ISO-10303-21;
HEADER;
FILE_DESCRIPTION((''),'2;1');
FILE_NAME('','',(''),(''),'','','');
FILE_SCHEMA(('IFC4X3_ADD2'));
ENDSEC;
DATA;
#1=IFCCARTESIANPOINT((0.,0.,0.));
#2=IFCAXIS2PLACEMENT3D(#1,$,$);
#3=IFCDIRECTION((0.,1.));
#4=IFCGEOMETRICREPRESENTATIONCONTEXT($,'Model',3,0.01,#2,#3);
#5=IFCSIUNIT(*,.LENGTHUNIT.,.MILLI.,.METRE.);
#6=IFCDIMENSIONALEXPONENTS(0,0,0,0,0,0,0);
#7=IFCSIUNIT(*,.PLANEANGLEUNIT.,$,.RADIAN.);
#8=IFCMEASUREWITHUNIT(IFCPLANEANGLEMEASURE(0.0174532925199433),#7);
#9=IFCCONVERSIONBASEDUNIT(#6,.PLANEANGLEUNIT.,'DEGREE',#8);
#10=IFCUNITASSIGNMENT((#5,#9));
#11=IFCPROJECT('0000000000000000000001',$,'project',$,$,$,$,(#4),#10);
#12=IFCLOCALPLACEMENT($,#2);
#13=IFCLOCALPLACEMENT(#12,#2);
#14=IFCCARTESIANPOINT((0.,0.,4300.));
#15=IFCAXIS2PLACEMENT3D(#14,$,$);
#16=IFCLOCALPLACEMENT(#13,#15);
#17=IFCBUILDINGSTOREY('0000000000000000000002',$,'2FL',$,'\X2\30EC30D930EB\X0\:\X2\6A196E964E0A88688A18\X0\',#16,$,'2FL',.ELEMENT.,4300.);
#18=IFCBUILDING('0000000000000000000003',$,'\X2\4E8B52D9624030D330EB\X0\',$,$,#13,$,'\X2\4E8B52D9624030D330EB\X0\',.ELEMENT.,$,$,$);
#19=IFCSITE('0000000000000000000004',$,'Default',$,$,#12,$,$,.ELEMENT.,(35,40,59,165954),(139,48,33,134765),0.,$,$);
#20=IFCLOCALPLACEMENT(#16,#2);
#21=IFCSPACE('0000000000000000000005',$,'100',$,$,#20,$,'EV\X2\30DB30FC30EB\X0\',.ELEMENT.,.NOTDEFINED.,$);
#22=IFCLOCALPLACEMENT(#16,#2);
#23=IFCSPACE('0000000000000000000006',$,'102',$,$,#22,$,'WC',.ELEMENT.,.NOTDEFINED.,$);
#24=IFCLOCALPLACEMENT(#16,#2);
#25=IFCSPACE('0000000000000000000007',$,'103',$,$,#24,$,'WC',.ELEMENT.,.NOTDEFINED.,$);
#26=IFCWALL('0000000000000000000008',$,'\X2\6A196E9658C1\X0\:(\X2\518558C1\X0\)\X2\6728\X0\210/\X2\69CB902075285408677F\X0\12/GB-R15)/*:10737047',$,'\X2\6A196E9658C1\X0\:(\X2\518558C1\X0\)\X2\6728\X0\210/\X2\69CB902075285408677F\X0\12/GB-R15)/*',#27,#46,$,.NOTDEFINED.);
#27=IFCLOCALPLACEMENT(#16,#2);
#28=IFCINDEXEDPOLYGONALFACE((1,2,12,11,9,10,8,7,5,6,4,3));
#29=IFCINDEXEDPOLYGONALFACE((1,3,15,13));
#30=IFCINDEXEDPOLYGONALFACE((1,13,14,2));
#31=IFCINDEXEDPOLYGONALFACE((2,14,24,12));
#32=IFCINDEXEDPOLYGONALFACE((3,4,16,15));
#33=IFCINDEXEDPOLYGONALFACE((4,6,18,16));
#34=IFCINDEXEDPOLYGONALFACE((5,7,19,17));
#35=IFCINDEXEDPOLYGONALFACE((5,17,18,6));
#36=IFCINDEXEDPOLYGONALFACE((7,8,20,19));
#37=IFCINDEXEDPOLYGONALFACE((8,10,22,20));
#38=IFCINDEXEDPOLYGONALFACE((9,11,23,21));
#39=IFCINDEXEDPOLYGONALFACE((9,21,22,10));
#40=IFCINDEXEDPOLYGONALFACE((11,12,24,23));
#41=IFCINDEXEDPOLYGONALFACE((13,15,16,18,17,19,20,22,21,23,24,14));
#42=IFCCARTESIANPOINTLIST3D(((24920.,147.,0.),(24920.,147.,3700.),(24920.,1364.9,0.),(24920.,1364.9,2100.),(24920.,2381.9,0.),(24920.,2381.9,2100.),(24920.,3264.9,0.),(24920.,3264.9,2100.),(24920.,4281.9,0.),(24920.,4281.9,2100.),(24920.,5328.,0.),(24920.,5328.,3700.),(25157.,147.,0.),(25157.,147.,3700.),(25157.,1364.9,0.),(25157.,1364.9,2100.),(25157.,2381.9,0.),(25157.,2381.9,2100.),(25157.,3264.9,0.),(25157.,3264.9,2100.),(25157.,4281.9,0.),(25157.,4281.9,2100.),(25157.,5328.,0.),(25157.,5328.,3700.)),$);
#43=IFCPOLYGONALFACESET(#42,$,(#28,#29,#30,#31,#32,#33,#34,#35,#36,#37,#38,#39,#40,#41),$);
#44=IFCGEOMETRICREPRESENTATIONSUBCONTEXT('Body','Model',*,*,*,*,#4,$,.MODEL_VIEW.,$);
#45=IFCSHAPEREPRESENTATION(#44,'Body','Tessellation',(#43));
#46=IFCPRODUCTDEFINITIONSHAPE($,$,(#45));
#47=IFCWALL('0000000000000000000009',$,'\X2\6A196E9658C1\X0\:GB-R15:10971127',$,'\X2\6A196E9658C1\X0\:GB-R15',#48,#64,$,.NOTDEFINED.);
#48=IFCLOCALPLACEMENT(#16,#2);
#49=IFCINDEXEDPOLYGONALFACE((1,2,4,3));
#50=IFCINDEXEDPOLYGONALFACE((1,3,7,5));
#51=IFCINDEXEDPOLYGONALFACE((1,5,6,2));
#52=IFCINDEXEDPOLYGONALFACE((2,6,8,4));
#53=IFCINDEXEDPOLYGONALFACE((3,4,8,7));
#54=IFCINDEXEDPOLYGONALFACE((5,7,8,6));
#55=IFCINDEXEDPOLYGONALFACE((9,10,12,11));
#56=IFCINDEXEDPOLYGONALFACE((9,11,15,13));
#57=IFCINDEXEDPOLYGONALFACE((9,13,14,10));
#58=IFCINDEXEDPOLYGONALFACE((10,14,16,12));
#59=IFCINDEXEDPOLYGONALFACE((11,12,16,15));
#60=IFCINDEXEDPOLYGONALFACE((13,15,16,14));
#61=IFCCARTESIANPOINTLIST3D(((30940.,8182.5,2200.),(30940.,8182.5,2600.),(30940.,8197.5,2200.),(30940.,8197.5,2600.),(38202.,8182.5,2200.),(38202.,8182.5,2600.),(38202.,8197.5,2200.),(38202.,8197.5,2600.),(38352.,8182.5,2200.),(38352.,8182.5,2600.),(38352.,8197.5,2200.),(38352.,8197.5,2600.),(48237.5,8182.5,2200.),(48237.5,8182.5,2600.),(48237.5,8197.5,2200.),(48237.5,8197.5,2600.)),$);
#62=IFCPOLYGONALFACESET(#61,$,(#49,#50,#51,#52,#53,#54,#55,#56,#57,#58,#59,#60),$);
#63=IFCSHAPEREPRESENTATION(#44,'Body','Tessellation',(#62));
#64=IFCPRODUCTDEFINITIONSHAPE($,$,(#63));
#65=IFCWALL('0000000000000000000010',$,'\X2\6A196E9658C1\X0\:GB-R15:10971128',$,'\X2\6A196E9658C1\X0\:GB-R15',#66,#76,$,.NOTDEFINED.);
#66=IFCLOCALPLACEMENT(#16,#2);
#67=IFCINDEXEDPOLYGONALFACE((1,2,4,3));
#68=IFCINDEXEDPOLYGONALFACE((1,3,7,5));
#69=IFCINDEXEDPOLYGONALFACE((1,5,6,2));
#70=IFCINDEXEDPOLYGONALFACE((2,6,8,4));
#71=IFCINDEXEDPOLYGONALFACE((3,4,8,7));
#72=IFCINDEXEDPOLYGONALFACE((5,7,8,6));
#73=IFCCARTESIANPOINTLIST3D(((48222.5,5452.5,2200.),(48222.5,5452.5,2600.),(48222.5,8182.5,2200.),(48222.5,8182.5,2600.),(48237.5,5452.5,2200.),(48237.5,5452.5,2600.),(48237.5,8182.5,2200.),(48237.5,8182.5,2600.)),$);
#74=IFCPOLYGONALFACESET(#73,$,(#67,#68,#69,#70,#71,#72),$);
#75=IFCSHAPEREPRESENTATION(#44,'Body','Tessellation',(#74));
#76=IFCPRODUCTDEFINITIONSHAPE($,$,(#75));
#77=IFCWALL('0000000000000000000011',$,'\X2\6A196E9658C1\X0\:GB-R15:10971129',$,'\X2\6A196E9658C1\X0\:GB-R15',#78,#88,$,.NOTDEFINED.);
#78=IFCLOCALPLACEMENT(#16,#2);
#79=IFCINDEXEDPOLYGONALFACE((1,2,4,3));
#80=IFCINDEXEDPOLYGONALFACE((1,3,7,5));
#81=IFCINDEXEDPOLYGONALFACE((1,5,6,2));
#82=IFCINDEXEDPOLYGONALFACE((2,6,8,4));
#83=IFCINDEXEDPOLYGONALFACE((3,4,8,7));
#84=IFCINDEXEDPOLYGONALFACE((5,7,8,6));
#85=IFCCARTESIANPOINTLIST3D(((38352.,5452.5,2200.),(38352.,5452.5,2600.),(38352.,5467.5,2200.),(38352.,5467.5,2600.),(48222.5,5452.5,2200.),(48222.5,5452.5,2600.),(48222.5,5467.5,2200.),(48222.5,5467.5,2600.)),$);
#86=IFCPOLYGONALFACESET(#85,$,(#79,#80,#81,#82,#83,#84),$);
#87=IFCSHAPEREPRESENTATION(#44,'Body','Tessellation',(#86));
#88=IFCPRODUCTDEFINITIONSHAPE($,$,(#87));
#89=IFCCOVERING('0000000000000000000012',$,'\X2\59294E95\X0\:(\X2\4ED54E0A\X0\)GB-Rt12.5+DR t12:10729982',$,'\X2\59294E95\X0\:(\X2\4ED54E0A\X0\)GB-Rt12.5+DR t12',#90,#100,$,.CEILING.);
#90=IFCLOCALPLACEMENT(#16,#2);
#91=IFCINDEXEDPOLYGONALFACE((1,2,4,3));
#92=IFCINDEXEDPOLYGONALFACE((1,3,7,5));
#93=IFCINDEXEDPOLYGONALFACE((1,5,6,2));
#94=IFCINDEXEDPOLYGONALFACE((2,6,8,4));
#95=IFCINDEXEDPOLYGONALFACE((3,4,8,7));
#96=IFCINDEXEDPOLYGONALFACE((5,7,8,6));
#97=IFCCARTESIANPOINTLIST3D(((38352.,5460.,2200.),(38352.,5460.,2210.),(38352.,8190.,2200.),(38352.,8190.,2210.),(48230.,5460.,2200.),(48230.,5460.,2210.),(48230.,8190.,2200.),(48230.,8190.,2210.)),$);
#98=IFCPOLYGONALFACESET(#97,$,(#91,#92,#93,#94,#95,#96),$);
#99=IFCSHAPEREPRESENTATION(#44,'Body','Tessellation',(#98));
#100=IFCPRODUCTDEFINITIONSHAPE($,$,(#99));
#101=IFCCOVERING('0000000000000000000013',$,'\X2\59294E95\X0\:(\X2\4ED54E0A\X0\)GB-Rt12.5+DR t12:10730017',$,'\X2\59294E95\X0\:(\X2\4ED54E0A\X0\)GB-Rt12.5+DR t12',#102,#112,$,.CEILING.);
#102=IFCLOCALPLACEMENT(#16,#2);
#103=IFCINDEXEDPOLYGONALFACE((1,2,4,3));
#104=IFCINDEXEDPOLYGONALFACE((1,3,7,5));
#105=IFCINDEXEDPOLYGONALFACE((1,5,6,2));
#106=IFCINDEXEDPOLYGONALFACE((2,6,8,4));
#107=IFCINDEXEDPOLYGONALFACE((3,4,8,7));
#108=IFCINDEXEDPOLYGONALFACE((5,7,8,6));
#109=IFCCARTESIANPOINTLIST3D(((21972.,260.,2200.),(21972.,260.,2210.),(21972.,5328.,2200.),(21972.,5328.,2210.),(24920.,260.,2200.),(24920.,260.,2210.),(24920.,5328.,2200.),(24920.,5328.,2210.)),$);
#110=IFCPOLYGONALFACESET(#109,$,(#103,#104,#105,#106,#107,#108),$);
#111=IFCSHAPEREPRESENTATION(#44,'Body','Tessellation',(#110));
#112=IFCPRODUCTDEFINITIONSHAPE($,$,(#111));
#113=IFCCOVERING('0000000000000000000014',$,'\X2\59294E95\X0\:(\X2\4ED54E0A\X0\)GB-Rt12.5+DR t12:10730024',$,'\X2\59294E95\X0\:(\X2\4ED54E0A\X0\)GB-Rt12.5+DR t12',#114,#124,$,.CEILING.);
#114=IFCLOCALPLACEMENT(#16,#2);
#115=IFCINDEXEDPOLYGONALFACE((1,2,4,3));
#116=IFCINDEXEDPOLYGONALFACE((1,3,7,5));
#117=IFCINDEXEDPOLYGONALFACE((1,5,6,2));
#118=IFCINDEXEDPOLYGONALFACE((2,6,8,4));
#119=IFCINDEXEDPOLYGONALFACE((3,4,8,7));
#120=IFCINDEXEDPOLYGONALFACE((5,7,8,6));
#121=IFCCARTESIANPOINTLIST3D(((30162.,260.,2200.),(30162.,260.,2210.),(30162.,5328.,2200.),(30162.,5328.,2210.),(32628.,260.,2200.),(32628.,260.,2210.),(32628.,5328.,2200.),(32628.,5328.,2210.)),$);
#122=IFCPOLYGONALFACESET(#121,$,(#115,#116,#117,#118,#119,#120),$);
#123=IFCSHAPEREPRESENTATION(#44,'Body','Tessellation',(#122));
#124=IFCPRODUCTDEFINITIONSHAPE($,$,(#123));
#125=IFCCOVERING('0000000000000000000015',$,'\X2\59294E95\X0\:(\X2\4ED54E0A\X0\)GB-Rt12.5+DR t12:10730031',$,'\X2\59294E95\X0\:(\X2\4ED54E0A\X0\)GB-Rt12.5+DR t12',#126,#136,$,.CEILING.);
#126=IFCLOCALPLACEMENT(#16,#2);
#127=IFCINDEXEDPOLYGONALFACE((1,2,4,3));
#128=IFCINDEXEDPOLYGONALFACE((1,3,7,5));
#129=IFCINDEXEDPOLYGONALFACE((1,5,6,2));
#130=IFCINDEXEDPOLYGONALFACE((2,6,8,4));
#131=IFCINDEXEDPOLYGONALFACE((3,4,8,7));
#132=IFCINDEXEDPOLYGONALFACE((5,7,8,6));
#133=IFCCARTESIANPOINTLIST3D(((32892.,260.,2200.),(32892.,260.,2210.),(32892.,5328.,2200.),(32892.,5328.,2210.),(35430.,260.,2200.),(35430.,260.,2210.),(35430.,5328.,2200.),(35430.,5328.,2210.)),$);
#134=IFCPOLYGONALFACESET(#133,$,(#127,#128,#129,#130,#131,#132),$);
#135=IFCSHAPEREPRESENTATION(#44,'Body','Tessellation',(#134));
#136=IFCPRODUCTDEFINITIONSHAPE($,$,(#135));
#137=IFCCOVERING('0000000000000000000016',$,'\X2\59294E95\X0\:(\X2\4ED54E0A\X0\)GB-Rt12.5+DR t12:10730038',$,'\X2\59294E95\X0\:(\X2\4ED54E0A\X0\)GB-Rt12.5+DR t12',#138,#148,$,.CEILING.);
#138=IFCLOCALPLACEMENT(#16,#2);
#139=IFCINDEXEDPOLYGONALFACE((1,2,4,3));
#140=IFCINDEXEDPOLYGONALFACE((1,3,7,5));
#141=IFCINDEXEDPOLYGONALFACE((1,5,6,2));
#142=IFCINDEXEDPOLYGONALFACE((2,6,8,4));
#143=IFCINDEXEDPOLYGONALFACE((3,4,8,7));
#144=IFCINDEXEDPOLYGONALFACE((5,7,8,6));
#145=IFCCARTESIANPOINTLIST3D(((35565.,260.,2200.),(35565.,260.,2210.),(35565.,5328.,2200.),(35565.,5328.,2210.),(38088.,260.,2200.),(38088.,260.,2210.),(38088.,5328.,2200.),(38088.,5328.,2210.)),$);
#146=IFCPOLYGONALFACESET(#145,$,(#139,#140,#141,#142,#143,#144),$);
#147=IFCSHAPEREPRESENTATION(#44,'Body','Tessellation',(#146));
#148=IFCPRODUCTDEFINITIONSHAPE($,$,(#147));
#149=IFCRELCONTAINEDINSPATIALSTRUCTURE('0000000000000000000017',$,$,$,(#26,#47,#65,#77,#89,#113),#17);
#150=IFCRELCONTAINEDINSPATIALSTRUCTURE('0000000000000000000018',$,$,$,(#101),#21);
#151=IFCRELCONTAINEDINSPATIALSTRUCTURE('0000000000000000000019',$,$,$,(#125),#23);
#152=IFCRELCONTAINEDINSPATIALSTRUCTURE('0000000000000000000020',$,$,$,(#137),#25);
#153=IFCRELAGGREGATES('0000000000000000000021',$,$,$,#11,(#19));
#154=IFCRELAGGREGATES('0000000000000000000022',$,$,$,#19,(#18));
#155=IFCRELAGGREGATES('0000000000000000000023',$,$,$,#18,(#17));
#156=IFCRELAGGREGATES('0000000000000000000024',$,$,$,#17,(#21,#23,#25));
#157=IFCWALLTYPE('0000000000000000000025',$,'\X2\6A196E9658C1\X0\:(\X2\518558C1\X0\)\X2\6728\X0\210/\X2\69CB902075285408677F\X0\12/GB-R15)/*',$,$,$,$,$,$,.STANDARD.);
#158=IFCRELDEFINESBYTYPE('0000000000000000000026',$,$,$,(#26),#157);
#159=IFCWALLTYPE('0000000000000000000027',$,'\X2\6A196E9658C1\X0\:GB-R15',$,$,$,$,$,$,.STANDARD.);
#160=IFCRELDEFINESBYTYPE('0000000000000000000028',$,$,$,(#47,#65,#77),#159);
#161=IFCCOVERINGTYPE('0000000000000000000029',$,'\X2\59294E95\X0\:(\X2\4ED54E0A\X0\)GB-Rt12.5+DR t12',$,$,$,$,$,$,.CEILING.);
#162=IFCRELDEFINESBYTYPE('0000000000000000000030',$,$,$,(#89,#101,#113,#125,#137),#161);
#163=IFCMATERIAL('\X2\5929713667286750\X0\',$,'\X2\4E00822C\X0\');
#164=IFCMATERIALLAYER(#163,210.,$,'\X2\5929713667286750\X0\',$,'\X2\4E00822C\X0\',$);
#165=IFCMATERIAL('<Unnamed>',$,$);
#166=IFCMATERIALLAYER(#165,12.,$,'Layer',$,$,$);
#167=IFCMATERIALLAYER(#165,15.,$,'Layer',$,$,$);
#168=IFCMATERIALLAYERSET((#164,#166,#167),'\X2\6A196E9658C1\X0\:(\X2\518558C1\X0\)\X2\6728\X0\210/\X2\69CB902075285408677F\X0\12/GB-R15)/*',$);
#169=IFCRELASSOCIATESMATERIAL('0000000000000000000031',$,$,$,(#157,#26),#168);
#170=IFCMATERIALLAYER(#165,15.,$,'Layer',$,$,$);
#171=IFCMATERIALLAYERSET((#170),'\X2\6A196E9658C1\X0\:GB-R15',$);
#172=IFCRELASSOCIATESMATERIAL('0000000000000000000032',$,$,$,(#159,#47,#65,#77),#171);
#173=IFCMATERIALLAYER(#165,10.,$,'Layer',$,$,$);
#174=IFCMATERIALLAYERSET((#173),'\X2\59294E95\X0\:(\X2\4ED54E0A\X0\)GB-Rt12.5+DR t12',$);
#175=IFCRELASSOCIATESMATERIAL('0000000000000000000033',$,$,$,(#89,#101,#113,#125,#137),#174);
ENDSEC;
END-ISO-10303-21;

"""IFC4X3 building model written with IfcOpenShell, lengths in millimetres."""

from ifc_helpers import new_model, entity, si_unit, converted_unit, direction, frame, frame_2d, origin, origin_2d_with_axis, place, context, subcontext, project, spatial, rectangle, extrude, material, layer, layer_set, layer_usage, type_object, element, save


model = new_model("IFC4X3")

# Units and contexts
model_context = context("Model", 3, precision=0.01, world=origin(), true_north=direction((0.0, 1.0)))
body_context = subcontext(model_context, "Body", "Model", "MODEL_VIEW")
ifc_project = project(units=[si_unit("LENGTHUNIT", "METRE", prefix="MILLI"), converted_unit("PLANEANGLEUNIT", "DEGREE", entity("IfcPlaneAngleMeasure", 0.0174532925199433), si_unit("PLANEANGLEUNIT", "RADIAN"), dimensions=[0, 0, 0, 0, 0, 0, 0])], contexts=[model_context])

# Site, building, storey
site_placement = place(None, origin())
site = spatial("IfcSite", under=ifc_project, at=site_placement, Name="Default", CompositionType="ELEMENT", RefLatitude=(35, 40, 59, 165954), RefLongitude=(139, 48, 33, 134765), RefElevation=0.0)
building_placement = place(site_placement, origin())
building = spatial("IfcBuilding", under=site, at=building_placement, Name="事務所ビル", LongName="事務所ビル", CompositionType="ELEMENT")
storey_placement = place(building_placement, frame((0.0, 0.0, 4300.0)))
storey = spatial("IfcBuildingStorey", under=building, at=storey_placement, Name="2FL", ObjectType="レベル:標準上表記", LongName="2FL", CompositionType="ELEMENT", Elevation=4300.0)

# Shared definitions
ifc_material_1 = material(Name="天然木材", Category="一般")

# Shared definitions
ifc_material_2 = material(Name="<Unnamed>")

# Wall, openings
ifc_layer_1 = layer(ifc_material_1, 210.0, Name="天然木材", Category="一般")
ifc_layer_2 = layer(ifc_material_2, 12.0, Name="Layer")
ifc_layer_3 = layer(ifc_material_2, 15.0, Name="Layer")
ifc_layer_set_1 = layer_set([ifc_layer_1, ifc_layer_2, ifc_layer_3], Name="標準壁:(内壁)木210/構造用合板12/GB-R15)/*")
wall_type_1 = type_object("IfcWallType", Name="標準壁:(内壁)木210/構造用合板12/GB-R15)/*", PredefinedType="STANDARD", material=ifc_layer_set_1)
wall_1_placement = place(storey_placement, frame((25038.5, 147.0, 0.0), z_axis=(0.0, 0.0, 1.0), x_axis=(0.0, 1.0, 0.0)))
wall_1 = element("IfcWall", 1, at=wall_1_placement, inside=storey, type_object=wall_type_1, material=ifc_layer_set_1, Name="標準壁:(内壁)木210/構造用合板12/GB-R15)/*:10737047", ObjectType="標準壁:(内壁)木210/構造用合板12/GB-R15)/*", PredefinedType="NOTDEFINED", context=body_context, shape_type="SweptSolid", body=[
    extrude(rectangle(XDim=5181.0, YDim=237.0, at=frame_2d((2590.5, 0.0), x_axis=(-1.0, 0.0))), origin(), (0.0, 0.0, 1.0), 3700.0),
])
opening_1_placement = place(wall_1_placement, frame((-147.0, 25038.5, 0.0)))
element("IfcOpeningElement", 2, at=opening_1_placement, cuts=wall_1, PredefinedType="OPENING", context=body_context, shape_type="SweptSolid", body=[
    extrude(rectangle(XDim=2100.0, YDim=1017.0, at=frame_2d((0.0, 0.0), x_axis=(1.0, 0.0))), frame((3773.4, -26444.0, 1050.0), z_axis=(0.0, 1.0, 0.0), x_axis=(0.0, 0.0, -1.0)), (0.0, 0.0, 1.0), 3048.0),
])
opening_2_placement = place(wall_1_placement, frame((-147.0, 25038.5, 0.0)))
element("IfcOpeningElement", 3, at=opening_2_placement, cuts=wall_1, PredefinedType="OPENING", context=body_context, shape_type="SweptSolid", body=[
    extrude(rectangle(XDim=2100.0, YDim=1017.0, at=frame_2d((0.0, 0.0), x_axis=(0.0, 1.0))), frame((1873.4, -26444.0, 1050.0), z_axis=(0.0, 1.0, 0.0), x_axis=(1.0, 0.0, 0.0)), (0.0, 0.0, 1.0), 3048.0),
])

# Wall, opening
ifc_layer_4 = layer(ifc_material_2, 15.0, Name="Layer")
ifc_layer_set_2 = layer_set([ifc_layer_4], Name="標準壁:GB-R15")
wall_type_2 = type_object("IfcWallType", Name="標準壁:GB-R15", PredefinedType="STANDARD", material=ifc_layer_set_2)
wall_2_placement = place(storey_placement, frame((30940.0, 8190.0, 2200.0)))
wall_2 = element("IfcWall", 4, at=wall_2_placement, inside=storey, type_object=wall_type_2, material=ifc_layer_set_2, Name="標準壁:GB-R15:10971127", ObjectType="標準壁:GB-R15", PredefinedType="NOTDEFINED", context=body_context, shape_type="SweptSolid", body=[
    extrude(rectangle(XDim=17297.5, YDim=15.0, at=frame_2d((8648.8, 0.0), x_axis=(-1.0, 0.0))), origin(), (0.0, 0.0, 1.0), 400.0),
])
opening_3_placement = place(storey_placement, frame((30940.0, 8190.0, 2200.0)))
element("IfcOpeningElement", 5, at=opening_3_placement, cuts=wall_2, PredefinedType="OPENING", context=body_context, shape_type="SweptSolid", body=[
    extrude(rectangle(XDim=400.0, YDim=15.0, at=frame_2d((0.0, 0.0), x_axis=(1.0, 0.0))), frame((7262.0, 0.0, 200.0), z_axis=(1.0, 0.0, 0.0), x_axis=(0.0, 0.0, -1.0)), (0.0, 0.0, 1.0), 150.0),
])

# Walls
wall_3_placement = place(storey_placement, frame((48230.0, 8182.5, 2200.0), z_axis=(0.0, 0.0, 1.0), x_axis=(0.0, -1.0, 0.0)))
element("IfcWall", 6, at=wall_3_placement, inside=storey, type_object=wall_type_2, material=ifc_layer_set_2, Name="標準壁:GB-R15:10971128", ObjectType="標準壁:GB-R15", PredefinedType="NOTDEFINED", context=body_context, shape_type="SweptSolid", body=[
    extrude(rectangle(XDim=2730.0, YDim=15.0, at=frame_2d((1365.0, 0.0), x_axis=(-1.0, 0.0))), origin(), (0.0, 0.0, 1.0), 400.0),
])
wall_4_placement = place(storey_placement, frame((48222.5, 5460.0, 2200.0), z_axis=(0.0, 0.0, 1.0), x_axis=(-1.0, 0.0, 0.0)))
element("IfcWall", 7, at=wall_4_placement, inside=storey, type_object=wall_type_2, material=ifc_layer_set_2, Name="標準壁:GB-R15:10971129", ObjectType="標準壁:GB-R15", PredefinedType="NOTDEFINED", context=body_context, shape_type="SweptSolid", body=[
    extrude(rectangle(XDim=9870.5, YDim=15.0, at=frame_2d((4935.2, 0.0), x_axis=(-1.0, 0.0))), origin(), (0.0, 0.0, 1.0), 400.0),
])

# Covering
ifc_layer_5 = layer(ifc_material_2, 10.0, Name="Layer")
ifc_layer_set_3 = layer_set([ifc_layer_5], Name="天井:(仕上)GB-Rt12.5+DR t12")
ifc_layer_usage_1 = layer_usage(ifc_layer_set_3, "AXIS3", "NEGATIVE", 0.0)
covering_type = type_object("IfcCoveringType", Name="天井:(仕上)GB-Rt12.5+DR t12", PredefinedType="CEILING")
covering_1_placement = place(storey_placement, frame((38352.0, 5460.0, 2200.0)))
element("IfcCovering", 8, at=covering_1_placement, inside=storey, type_object=covering_type, material=ifc_layer_usage_1, Name="天井:(仕上)GB-Rt12.5+DR t12:10729982", ObjectType="天井:(仕上)GB-Rt12.5+DR t12", PredefinedType="CEILING", context=body_context, shape_type="SweptSolid", body=[
    extrude(rectangle(XDim=9878.0, YDim=2730.0, at=origin_2d_with_axis()), frame((4939.0, 1365.0, 0.0), z_axis=(0.0, 0.0, 1.0), x_axis=(-1.0, 0.0, 0.0)), (0.0, 0.0, 1.0), 10.0),
])

# Shared definitions
space_1_placement = place(storey_placement, origin())
space_1 = spatial("IfcSpace", under=storey, at=space_1_placement, Name="100", LongName="EVホール", CompositionType="ELEMENT", PredefinedType="NOTDEFINED")

# Coverings
ifc_layer_usage_2 = layer_usage(ifc_layer_set_3, "AXIS3", "NEGATIVE", 0.0)
covering_2_placement = place(space_1_placement, frame((21972.0, 260.0, 2200.0)))
element("IfcCovering", 9, at=covering_2_placement, inside=space_1, type_object=covering_type, material=ifc_layer_usage_2, Name="天井:(仕上)GB-Rt12.5+DR t12:10730017", ObjectType="天井:(仕上)GB-Rt12.5+DR t12", PredefinedType="CEILING", context=body_context, shape_type="SweptSolid", body=[
    extrude(rectangle(XDim=2948.0, YDim=5068.0, at=frame_2d((0.0, 0.0), x_axis=(1.0, 0.0))), frame((1474.0, 2534.0, 0.0), z_axis=(0.0, 0.0, 1.0), x_axis=(-1.0, 0.0, 0.0)), (0.0, 0.0, 1.0), 10.0),
])
ifc_layer_usage_3 = layer_usage(ifc_layer_set_3, "AXIS3", "NEGATIVE", 0.0)
covering_3_placement = place(storey_placement, frame((30162.0, 260.0, 2200.0)))
element("IfcCovering", 10, at=covering_3_placement, inside=storey, type_object=covering_type, material=ifc_layer_usage_3, Name="天井:(仕上)GB-Rt12.5+DR t12:10730024", ObjectType="天井:(仕上)GB-Rt12.5+DR t12", PredefinedType="CEILING", context=body_context, shape_type="SweptSolid", body=[
    extrude(rectangle(XDim=2466.0, YDim=5068.0, at=frame_2d((0.0, 0.0), x_axis=(1.0, 0.0))), frame((1233.0, 2534.0, 0.0), z_axis=(0.0, 0.0, 1.0), x_axis=(-1.0, 0.0, 0.0)), (0.0, 0.0, 1.0), 10.0),
])

# Shared definitions
space_2_placement = place(storey_placement, origin())
space_2 = spatial("IfcSpace", under=storey, at=space_2_placement, Name="102", LongName="WC", CompositionType="ELEMENT", PredefinedType="NOTDEFINED")

# Covering
ifc_layer_usage_4 = layer_usage(ifc_layer_set_3, "AXIS3", "NEGATIVE", 0.0)
covering_4_placement = place(space_2_placement, frame((32892.0, 260.0, 2200.0)))
element("IfcCovering", 11, at=covering_4_placement, inside=space_2, type_object=covering_type, material=ifc_layer_usage_4, Name="天井:(仕上)GB-Rt12.5+DR t12:10730031", ObjectType="天井:(仕上)GB-Rt12.5+DR t12", PredefinedType="CEILING", context=body_context, shape_type="SweptSolid", body=[
    extrude(rectangle(XDim=2538.0, YDim=5068.0, at=frame_2d((0.0, 0.0), x_axis=(1.0, 0.0))), frame((1269.0, 2534.0, 0.0), z_axis=(0.0, 0.0, 1.0), x_axis=(-1.0, 0.0, 0.0)), (0.0, 0.0, 1.0), 10.0),
])

# Shared definitions
space_3_placement = place(storey_placement, origin())
space_3 = spatial("IfcSpace", under=storey, at=space_3_placement, Name="103", LongName="WC", CompositionType="ELEMENT", PredefinedType="NOTDEFINED")

# Covering
ifc_layer_usage_5 = layer_usage(ifc_layer_set_3, "AXIS3", "NEGATIVE", 0.0)
covering_5_placement = place(space_3_placement, frame((35565.0, 260.0, 2200.0)))
element("IfcCovering", 12, at=covering_5_placement, inside=space_3, type_object=covering_type, material=ifc_layer_usage_5, Name="天井:(仕上)GB-Rt12.5+DR t12:10730038", ObjectType="天井:(仕上)GB-Rt12.5+DR t12", PredefinedType="CEILING", context=body_context, shape_type="SweptSolid", body=[
    extrude(rectangle(XDim=2523.0, YDim=5068.0, at=frame_2d((0.0, 0.0), x_axis=(1.0, 0.0))), frame((1261.5, 2534.0, 0.0), z_axis=(0.0, 0.0, 1.0), x_axis=(-1.0, 0.0, 0.0)), (0.0, 0.0, 1.0), 10.0),
])

save(model, "model.ifc")
